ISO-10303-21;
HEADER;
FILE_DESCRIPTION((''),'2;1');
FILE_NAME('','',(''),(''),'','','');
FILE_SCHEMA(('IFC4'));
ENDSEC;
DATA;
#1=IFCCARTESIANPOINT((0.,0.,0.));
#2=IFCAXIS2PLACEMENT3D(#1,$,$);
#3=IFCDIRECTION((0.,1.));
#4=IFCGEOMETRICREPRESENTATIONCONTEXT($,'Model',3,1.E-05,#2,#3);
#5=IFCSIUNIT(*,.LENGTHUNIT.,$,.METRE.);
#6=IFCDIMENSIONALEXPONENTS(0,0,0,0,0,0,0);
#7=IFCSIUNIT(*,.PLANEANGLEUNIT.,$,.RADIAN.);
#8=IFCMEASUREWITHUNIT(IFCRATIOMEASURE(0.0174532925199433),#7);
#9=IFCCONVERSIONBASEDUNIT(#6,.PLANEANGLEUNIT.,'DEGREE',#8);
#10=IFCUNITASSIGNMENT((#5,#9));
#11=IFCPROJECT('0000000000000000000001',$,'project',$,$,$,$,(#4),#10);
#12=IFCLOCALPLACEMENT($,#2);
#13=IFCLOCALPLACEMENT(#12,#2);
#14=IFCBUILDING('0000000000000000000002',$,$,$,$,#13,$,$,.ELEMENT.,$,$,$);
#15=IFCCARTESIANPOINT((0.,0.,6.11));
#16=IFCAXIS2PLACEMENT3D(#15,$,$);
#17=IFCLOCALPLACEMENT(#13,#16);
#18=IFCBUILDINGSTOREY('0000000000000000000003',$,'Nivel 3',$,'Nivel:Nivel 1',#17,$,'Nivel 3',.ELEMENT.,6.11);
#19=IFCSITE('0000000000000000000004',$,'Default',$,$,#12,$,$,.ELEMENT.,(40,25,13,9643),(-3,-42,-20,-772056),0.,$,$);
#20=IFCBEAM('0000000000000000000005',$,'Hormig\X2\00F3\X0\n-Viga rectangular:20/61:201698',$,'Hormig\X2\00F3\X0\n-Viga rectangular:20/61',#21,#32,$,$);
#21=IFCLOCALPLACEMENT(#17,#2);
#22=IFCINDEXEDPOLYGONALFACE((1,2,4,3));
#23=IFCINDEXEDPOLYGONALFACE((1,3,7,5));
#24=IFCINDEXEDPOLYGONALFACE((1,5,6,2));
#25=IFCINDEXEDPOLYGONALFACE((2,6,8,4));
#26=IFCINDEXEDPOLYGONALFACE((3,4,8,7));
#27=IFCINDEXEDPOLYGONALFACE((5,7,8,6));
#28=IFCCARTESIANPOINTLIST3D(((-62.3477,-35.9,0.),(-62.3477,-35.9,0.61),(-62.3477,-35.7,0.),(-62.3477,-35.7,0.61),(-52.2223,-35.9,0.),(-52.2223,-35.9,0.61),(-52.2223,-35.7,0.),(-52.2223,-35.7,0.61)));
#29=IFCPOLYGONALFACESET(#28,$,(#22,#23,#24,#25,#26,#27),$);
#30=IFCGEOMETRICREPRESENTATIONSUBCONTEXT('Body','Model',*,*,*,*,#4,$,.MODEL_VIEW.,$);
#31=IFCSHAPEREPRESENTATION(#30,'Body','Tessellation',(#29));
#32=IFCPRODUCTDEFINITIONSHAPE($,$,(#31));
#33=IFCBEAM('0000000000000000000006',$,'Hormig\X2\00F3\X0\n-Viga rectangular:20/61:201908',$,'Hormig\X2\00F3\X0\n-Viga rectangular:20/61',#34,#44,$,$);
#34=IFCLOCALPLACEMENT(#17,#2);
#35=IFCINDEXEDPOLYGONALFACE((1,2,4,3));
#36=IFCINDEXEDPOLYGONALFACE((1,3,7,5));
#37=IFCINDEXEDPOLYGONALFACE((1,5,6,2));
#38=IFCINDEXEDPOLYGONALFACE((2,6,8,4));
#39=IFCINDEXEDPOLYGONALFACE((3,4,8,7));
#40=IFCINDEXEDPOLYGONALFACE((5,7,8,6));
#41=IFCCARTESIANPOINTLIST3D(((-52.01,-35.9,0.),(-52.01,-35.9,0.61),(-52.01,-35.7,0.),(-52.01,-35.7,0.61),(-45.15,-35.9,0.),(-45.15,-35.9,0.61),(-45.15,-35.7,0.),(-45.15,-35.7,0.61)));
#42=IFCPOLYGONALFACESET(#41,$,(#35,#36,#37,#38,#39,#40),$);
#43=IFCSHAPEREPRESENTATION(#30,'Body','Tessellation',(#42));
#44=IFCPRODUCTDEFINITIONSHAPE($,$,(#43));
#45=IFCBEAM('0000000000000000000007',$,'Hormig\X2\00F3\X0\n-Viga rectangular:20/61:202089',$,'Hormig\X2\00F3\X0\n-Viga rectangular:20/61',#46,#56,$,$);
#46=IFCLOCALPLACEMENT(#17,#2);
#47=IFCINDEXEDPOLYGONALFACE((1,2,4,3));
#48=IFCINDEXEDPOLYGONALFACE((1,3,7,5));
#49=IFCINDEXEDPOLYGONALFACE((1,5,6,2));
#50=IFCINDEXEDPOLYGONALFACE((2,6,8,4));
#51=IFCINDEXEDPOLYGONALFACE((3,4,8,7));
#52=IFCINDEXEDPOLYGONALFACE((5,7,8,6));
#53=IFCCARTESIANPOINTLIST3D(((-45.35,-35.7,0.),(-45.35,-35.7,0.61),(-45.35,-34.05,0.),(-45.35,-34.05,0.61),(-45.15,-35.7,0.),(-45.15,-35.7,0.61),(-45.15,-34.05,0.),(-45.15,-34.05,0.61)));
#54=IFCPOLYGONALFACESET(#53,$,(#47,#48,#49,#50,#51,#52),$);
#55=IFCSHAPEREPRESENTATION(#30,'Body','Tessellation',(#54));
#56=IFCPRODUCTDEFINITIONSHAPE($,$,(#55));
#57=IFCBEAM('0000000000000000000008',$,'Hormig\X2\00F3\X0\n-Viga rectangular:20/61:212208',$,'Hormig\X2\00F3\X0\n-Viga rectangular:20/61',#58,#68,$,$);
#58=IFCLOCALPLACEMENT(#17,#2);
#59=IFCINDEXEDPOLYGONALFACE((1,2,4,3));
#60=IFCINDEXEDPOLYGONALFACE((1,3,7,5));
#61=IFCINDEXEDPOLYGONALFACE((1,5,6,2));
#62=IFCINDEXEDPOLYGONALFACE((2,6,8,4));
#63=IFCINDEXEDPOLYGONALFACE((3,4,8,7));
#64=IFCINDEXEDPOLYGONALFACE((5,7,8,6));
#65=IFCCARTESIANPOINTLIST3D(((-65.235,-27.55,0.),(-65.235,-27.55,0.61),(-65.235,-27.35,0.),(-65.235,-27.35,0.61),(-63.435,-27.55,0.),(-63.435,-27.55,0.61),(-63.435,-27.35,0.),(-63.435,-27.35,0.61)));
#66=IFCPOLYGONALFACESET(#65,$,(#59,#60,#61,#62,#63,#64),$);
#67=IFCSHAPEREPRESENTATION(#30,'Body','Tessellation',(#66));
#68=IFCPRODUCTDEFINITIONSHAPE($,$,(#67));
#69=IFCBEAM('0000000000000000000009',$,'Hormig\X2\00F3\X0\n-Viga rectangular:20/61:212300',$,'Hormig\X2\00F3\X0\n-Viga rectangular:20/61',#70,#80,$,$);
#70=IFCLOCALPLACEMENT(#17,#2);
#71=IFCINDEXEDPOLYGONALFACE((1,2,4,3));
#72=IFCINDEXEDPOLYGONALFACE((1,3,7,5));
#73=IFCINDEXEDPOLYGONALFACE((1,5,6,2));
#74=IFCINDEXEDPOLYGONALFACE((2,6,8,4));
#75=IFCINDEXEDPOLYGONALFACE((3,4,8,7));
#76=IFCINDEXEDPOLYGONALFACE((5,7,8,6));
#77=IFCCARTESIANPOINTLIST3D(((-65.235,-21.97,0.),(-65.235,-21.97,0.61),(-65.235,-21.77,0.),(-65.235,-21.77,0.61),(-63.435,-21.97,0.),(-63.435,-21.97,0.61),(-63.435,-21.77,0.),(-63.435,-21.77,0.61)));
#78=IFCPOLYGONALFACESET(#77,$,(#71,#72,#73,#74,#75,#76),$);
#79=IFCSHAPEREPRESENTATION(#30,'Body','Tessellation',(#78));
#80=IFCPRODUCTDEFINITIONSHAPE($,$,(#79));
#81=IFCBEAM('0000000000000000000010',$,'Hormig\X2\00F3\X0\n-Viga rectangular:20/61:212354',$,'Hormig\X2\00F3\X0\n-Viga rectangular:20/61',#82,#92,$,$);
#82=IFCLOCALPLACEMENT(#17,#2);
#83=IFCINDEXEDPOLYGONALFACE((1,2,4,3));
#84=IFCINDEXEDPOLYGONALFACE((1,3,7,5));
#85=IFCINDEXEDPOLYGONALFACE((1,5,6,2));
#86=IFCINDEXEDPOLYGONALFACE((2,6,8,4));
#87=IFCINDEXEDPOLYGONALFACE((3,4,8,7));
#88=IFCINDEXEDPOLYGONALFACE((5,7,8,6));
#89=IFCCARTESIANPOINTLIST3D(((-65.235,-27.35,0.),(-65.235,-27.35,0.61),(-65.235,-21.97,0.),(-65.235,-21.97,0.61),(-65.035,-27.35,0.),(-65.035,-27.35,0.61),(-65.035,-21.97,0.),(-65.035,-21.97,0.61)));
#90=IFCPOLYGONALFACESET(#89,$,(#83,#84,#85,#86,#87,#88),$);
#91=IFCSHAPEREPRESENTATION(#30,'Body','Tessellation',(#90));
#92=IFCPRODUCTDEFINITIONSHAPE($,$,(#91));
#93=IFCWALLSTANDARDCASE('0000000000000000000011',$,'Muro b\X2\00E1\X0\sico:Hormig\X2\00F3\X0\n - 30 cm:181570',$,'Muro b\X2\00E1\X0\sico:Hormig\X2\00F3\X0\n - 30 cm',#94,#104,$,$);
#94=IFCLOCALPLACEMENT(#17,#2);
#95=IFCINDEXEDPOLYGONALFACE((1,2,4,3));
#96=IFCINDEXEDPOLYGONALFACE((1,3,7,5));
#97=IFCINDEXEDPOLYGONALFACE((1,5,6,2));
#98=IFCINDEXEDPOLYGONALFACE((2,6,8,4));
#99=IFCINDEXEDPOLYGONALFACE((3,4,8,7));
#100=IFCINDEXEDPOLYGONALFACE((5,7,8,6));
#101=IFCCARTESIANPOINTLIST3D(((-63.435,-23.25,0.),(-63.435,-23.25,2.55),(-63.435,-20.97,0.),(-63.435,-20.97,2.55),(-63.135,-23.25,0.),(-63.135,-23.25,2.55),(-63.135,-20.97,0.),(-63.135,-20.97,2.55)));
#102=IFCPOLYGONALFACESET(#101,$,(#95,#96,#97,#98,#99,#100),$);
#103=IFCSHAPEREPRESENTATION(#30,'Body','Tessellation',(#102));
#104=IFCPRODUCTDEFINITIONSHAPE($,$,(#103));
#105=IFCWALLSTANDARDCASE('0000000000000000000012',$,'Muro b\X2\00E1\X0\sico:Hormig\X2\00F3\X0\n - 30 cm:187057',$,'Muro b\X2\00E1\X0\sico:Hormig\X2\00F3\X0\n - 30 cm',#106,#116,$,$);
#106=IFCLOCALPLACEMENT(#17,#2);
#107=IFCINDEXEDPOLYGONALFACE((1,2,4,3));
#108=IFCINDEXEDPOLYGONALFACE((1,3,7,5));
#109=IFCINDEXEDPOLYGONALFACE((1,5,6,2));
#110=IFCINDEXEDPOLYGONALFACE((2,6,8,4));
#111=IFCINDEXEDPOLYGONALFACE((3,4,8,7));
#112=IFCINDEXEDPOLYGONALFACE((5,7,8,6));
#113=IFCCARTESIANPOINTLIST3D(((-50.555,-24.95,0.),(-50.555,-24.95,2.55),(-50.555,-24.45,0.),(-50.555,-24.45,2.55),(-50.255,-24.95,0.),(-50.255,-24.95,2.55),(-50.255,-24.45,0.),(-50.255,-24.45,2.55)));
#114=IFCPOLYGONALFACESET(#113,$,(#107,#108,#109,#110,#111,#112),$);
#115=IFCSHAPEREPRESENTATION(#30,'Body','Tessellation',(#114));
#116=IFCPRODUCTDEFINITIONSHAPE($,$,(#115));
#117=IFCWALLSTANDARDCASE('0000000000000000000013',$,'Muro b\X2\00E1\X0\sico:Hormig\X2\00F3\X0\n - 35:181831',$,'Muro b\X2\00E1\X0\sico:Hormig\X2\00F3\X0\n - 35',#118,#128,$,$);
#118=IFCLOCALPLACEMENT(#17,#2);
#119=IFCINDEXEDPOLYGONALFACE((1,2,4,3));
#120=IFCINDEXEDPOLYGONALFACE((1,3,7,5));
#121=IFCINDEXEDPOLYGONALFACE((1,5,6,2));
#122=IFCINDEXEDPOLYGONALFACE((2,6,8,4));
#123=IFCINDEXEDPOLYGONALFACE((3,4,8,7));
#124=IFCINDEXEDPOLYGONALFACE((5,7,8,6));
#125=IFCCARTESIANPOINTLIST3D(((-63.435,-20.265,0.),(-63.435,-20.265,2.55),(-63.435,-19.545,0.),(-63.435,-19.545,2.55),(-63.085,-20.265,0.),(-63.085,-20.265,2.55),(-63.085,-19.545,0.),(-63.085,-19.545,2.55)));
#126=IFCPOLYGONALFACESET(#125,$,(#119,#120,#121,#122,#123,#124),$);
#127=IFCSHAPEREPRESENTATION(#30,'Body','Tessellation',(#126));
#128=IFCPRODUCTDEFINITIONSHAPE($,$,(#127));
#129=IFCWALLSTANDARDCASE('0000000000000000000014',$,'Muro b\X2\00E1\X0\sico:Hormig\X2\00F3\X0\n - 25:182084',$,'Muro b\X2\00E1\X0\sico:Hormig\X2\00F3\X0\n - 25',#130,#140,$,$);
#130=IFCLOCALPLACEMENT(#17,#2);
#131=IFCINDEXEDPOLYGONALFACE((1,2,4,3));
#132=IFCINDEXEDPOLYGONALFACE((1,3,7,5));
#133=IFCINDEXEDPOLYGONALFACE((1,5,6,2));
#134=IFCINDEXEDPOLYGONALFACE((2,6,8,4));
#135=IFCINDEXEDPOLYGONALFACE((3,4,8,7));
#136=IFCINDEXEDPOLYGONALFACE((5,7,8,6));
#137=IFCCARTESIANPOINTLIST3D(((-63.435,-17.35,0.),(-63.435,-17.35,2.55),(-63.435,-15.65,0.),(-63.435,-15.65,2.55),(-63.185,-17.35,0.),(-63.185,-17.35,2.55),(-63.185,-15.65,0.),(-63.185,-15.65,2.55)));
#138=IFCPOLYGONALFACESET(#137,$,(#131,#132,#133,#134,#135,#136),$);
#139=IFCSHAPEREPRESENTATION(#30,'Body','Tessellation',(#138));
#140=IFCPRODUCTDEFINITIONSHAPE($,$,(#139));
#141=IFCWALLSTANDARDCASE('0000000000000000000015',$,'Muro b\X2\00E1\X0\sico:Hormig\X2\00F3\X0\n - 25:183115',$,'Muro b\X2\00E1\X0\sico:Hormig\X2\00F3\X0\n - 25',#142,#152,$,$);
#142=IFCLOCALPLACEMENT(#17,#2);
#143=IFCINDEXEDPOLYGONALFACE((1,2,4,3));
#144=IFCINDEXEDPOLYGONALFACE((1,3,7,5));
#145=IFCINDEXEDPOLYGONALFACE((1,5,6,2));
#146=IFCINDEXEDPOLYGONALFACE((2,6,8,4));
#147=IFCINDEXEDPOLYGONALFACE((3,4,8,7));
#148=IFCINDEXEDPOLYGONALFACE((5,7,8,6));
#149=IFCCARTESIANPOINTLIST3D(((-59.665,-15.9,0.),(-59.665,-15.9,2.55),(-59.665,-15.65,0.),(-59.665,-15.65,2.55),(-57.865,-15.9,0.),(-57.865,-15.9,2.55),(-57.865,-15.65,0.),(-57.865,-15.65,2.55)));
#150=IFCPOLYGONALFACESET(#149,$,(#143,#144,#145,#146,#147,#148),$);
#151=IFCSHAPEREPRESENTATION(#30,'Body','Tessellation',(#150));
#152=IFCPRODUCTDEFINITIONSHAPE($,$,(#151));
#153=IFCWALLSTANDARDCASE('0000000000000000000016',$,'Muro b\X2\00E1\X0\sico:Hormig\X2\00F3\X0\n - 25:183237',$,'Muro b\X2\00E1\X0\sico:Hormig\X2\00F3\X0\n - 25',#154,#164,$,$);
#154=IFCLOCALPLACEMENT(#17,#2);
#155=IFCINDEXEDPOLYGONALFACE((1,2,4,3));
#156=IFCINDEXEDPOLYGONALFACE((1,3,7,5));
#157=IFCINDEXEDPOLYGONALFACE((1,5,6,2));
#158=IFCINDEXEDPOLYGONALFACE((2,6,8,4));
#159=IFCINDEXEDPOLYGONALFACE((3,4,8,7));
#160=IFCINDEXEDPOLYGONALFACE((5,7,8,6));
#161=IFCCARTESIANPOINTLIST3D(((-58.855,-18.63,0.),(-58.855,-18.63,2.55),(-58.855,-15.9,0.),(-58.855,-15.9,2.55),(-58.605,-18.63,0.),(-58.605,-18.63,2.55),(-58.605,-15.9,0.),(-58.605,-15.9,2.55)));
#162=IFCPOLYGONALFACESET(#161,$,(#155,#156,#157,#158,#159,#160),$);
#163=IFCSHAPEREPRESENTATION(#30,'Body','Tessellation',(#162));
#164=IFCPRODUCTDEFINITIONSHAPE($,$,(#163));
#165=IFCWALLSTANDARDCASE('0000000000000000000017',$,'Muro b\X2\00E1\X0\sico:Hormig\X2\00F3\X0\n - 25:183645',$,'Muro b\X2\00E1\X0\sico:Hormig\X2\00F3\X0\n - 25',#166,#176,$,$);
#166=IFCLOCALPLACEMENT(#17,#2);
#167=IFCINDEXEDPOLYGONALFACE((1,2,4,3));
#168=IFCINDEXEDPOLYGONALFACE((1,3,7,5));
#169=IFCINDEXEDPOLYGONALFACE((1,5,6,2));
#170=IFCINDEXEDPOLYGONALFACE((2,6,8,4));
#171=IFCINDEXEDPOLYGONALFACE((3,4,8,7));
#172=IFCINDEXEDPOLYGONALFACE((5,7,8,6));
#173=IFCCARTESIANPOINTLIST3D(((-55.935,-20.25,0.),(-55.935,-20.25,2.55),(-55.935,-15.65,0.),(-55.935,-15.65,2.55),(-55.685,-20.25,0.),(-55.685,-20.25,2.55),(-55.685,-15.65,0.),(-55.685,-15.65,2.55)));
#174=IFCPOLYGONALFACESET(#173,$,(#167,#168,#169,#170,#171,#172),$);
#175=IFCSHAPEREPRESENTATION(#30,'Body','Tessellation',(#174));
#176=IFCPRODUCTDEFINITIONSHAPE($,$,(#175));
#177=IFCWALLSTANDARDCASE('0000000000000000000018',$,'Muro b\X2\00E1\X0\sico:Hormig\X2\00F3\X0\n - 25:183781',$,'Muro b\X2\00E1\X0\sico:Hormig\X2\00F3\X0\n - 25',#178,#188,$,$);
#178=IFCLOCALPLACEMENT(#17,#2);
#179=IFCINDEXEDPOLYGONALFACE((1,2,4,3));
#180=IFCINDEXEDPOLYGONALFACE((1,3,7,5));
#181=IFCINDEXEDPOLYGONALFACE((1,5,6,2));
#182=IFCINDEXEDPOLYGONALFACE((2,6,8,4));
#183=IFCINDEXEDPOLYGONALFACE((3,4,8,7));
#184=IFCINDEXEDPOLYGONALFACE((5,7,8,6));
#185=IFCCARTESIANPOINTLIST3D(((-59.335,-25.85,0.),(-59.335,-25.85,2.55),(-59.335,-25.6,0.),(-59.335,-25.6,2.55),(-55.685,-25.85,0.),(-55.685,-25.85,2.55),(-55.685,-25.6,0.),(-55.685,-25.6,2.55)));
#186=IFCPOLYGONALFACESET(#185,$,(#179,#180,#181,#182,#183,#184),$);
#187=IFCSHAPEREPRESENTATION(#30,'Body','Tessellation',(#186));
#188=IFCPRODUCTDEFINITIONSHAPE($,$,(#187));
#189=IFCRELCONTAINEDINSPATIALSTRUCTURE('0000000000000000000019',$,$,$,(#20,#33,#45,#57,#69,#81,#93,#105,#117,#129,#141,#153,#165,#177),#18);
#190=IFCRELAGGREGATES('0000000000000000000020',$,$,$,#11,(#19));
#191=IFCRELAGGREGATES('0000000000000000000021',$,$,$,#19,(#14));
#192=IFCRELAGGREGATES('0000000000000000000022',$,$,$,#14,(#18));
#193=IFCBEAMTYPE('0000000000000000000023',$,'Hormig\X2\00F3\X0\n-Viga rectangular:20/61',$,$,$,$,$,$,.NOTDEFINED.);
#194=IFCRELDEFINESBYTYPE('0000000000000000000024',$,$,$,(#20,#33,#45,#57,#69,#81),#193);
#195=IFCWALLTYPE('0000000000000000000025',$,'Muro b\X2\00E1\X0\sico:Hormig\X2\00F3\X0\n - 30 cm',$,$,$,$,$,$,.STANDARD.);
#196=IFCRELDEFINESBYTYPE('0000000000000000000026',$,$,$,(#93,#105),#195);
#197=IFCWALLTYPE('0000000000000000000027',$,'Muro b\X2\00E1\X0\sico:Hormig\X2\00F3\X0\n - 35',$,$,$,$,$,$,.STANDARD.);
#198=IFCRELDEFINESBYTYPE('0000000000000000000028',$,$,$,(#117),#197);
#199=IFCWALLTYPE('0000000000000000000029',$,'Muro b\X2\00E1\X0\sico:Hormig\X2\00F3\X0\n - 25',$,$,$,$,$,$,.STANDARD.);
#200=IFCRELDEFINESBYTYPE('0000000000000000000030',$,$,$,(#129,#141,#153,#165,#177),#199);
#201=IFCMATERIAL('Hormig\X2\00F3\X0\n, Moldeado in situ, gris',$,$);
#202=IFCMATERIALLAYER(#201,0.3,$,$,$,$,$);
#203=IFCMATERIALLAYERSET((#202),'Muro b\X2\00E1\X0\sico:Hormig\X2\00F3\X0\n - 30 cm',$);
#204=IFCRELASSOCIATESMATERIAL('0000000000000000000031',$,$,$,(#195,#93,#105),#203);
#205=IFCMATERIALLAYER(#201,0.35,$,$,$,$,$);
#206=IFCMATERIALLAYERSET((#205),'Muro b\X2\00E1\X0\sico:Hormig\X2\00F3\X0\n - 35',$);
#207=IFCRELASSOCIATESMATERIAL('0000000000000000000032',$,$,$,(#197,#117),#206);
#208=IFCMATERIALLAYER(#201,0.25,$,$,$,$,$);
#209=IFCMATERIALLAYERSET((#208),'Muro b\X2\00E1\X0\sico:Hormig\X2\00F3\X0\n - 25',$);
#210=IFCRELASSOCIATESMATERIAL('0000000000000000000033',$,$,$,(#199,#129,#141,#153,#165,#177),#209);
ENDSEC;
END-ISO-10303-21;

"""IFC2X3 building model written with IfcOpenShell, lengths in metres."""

from ifc_helpers import new_model, entity, si_unit, converted_unit, direction, frame, frame_2d, origin, origin_2d_with_axis, place, context, subcontext, project, spatial, rectangle, extrude, material, layer, layer_set, layer_usage, type_object, element, save


model = new_model("IFC2X3")

# Units and contexts
model_context = context("Model", 3, precision=1e-05, world=origin(), true_north=direction((0.0, 1.0)))
body_context = subcontext(model_context, "Body", "Model", "MODEL_VIEW")
ifc_project = project(units=[si_unit("LENGTHUNIT", "METRE"), converted_unit("PLANEANGLEUNIT", "DEGREE", entity("IfcRatioMeasure", 0.0174532925199433), si_unit("PLANEANGLEUNIT", "RADIAN"), dimensions=[0, 0, 0, 0, 0, 0, 0])], contexts=[model_context])

# Site, building, storey
site_placement = place(None, origin())
site = spatial("IfcSite", under=ifc_project, at=site_placement, Name="Default", CompositionType="ELEMENT", RefLatitude=(40, 25, 13, 9643), RefLongitude=(-3, -42, -20, -772056), RefElevation=0.0)
building_placement = place(site_placement, origin())
building = spatial("IfcBuilding", under=site, at=building_placement, CompositionType="ELEMENT")
storey_placement = place(building_placement, frame((0.0, 0.0, 6.11)))
storey = spatial("IfcBuildingStorey", under=building, at=storey_placement, Name="Nivel 3", ObjectType="Nivel:Nivel 1", LongName="Nivel 3", CompositionType="ELEMENT", Elevation=6.11)

# Beams
beam_type = type_object("IfcBeamType", Name="Hormigón-Viga rectangular:20/61", PredefinedType="NOTDEFINED")
beam_1_placement = place(storey_placement, frame((-62.335, -35.8, 0.61)))
element("IfcBeam", 1, at=beam_1_placement, inside=storey, type_object=beam_type, Name="Hormigón-Viga rectangular:20/61:201698", ObjectType="Hormigón-Viga rectangular:20/61", context=body_context, shape_type="SweptSolid", body=[
    extrude(rectangle(XDim=0.61, YDim=0.2, at=frame_2d((0.0, 0.0), x_axis=(1.0, 0.0))), frame((-0.0127, 0.0, -0.305), z_axis=(1.0, 0.0, 0.0), x_axis=(0.0, 0.0, -1.0)), (0.0, 0.0, 1.0), 10.1254),
])
beam_2_placement = place(storey_placement, frame((-51.9973, -35.8, 0.61)))
element("IfcBeam", 2, at=beam_2_placement, inside=storey, type_object=beam_type, Name="Hormigón-Viga rectangular:20/61:201908", ObjectType="Hormigón-Viga rectangular:20/61", context=body_context, shape_type="SweptSolid", body=[
    extrude(rectangle(XDim=0.61, YDim=0.2, at=frame_2d((0.0, 0.0), x_axis=(1.0, 0.0))), frame((-0.0127, 0.0, -0.305), z_axis=(1.0, 0.0, 0.0), x_axis=(0.0, 0.0, -1.0)), (0.0, 0.0, 1.0), 6.86),
])
beam_3_placement = place(storey_placement, frame((-45.25, -35.8, 0.61), z_axis=(0.0, 0.0, 1.0), x_axis=(0.0, 1.0, 0.0)))
element("IfcBeam", 3, at=beam_3_placement, inside=storey, type_object=beam_type, Name="Hormigón-Viga rectangular:20/61:202089", ObjectType="Hormigón-Viga rectangular:20/61", context=body_context, shape_type="SweptSolid", body=[
    extrude(rectangle(XDim=0.61, YDim=0.2, at=origin_2d_with_axis()), frame((0.1, 0.0, -0.305), z_axis=(1.0, 0.0, 0.0), x_axis=(0.0, 0.0, -1.0)), (0.0, 0.0, 1.0), 1.65),
])
beam_4_placement = place(storey_placement, frame((-65.135, -27.45, 0.61)))
element("IfcBeam", 4, at=beam_4_placement, inside=storey, type_object=beam_type, Name="Hormigón-Viga rectangular:20/61:212208", ObjectType="Hormigón-Viga rectangular:20/61", context=body_context, shape_type="SweptSolid", body=[
    extrude(rectangle(XDim=0.61, YDim=0.2, at=frame_2d((0.0, 0.0), x_axis=(1.0, 0.0))), frame((-0.1, 0.0, -0.305), z_axis=(1.0, 0.0, 0.0), x_axis=(0.0, 0.0, -1.0)), (0.0, 0.0, 1.0), 1.8),
])
beam_5_placement = place(storey_placement, frame((-65.135, -21.87, 0.61)))
element("IfcBeam", 5, at=beam_5_placement, inside=storey, type_object=beam_type, Name="Hormigón-Viga rectangular:20/61:212300", ObjectType="Hormigón-Viga rectangular:20/61", context=body_context, shape_type="SweptSolid", body=[
    extrude(rectangle(XDim=0.61, YDim=0.2, at=frame_2d((0.0, 0.0), x_axis=(1.0, 0.0))), frame((-0.1, 0.0, -0.305), z_axis=(1.0, 0.0, 0.0), x_axis=(0.0, 0.0, -1.0)), (0.0, 0.0, 1.0), 1.8),
])
beam_6_placement = place(storey_placement, frame((-65.135, -21.87, 0.61), z_axis=(0.0, 0.0, 1.0), x_axis=(0.0, -1.0, 0.0)))
element("IfcBeam", 6, at=beam_6_placement, inside=storey, type_object=beam_type, Name="Hormigón-Viga rectangular:20/61:212354", ObjectType="Hormigón-Viga rectangular:20/61", context=body_context, shape_type="SweptSolid", body=[
    extrude(rectangle(XDim=0.61, YDim=0.2, at=origin_2d_with_axis()), frame((0.1, 0.0, -0.305), z_axis=(1.0, 0.0, 0.0), x_axis=(0.0, 0.0, -1.0)), (0.0, 0.0, 1.0), 5.38),
])

# Walls
ifc_material = material(Name="Hormigón, Moldeado in situ, gris")
ifc_layer_1 = layer(ifc_material, 0.3)
ifc_layer_set_1 = layer_set([ifc_layer_1], Name="Muro básico:Hormigón - 30 cm")
ifc_layer_usage_1 = layer_usage(ifc_layer_set_1, "AXIS2", "NEGATIVE", 0.15)
wall_type_1 = type_object("IfcWallType", Name="Muro básico:Hormigón - 30 cm", PredefinedType="STANDARD", material=ifc_layer_set_1)
wall_1_placement = place(storey_placement, frame((-63.285, -23.25, 0.0), z_axis=(0.0, 0.0, 1.0), x_axis=(0.0, 1.0, 0.0)))
element("IfcWallStandardCase", 7, at=wall_1_placement, inside=storey, type_object=wall_type_1, material=ifc_layer_usage_1, Name="Muro básico:Hormigón - 30 cm:181570", ObjectType="Muro básico:Hormigón - 30 cm", context=body_context, shape_type="SweptSolid", body=[
    extrude(rectangle(XDim=2.28, YDim=0.3, at=frame_2d((1.14, 0.0), x_axis=(-1.0, 0.0))), origin(), (0.0, 0.0, 1.0), 2.55),
])
ifc_layer_usage_2 = layer_usage(ifc_layer_set_1, "AXIS2", "NEGATIVE", 0.15)
wall_2_placement = place(storey_placement, frame((-50.405, -24.95, 0.0), z_axis=(0.0, 0.0, 1.0), x_axis=(0.0, 1.0, 0.0)))
element("IfcWallStandardCase", 8, at=wall_2_placement, inside=storey, type_object=wall_type_1, material=ifc_layer_usage_2, Name="Muro básico:Hormigón - 30 cm:187057", ObjectType="Muro básico:Hormigón - 30 cm", context=body_context, shape_type="SweptSolid", body=[
    extrude(rectangle(XDim=0.5, YDim=0.3, at=frame_2d((0.25, 0.0), x_axis=(-1.0, 0.0))), origin(), (0.0, 0.0, 1.0), 2.55),
])
ifc_layer_2 = layer(ifc_material, 0.35)
ifc_layer_set_2 = layer_set([ifc_layer_2], Name="Muro básico:Hormigón - 35")
ifc_layer_usage_3 = layer_usage(ifc_layer_set_2, "AXIS2", "NEGATIVE", 0.175)
wall_type_2 = type_object("IfcWallType", Name="Muro básico:Hormigón - 35", PredefinedType="STANDARD", material=ifc_layer_set_2)
wall_3_placement = place(storey_placement, frame((-63.26, -20.265, 0.0), z_axis=(0.0, 0.0, 1.0), x_axis=(0.0, 1.0, 0.0)))
element("IfcWallStandardCase", 9, at=wall_3_placement, inside=storey, type_object=wall_type_2, material=ifc_layer_usage_3, Name="Muro básico:Hormigón - 35:181831", ObjectType="Muro básico:Hormigón - 35", context=body_context, shape_type="SweptSolid", body=[
    extrude(rectangle(XDim=0.72, YDim=0.35, at=frame_2d((0.36, 0.0), x_axis=(-1.0, 0.0))), origin(), (0.0, 0.0, 1.0), 2.55),
])
ifc_layer_3 = layer(ifc_material, 0.25)
ifc_layer_set_3 = layer_set([ifc_layer_3], Name="Muro básico:Hormigón - 25")
ifc_layer_usage_4 = layer_usage(ifc_layer_set_3, "AXIS2", "NEGATIVE", 0.125)
wall_type_3 = type_object("IfcWallType", Name="Muro básico:Hormigón - 25", PredefinedType="STANDARD", material=ifc_layer_set_3)
wall_4_placement = place(storey_placement, frame((-63.31, -17.35, 0.0), z_axis=(0.0, 0.0, 1.0), x_axis=(0.0, 1.0, 0.0)))
element("IfcWallStandardCase", 10, at=wall_4_placement, inside=storey, type_object=wall_type_3, material=ifc_layer_usage_4, Name="Muro básico:Hormigón - 25:182084", ObjectType="Muro básico:Hormigón - 25", context=body_context, shape_type="SweptSolid", body=[
    extrude(rectangle(XDim=1.7, YDim=0.25, at=frame_2d((0.85, 0.0), x_axis=(-1.0, 0.0))), origin(), (0.0, 0.0, 1.0), 2.55),
])
ifc_layer_usage_5 = layer_usage(ifc_layer_set_3, "AXIS2", "NEGATIVE", 0.125)
wall_5_placement = place(storey_placement, frame((-59.665, -15.775, 0.0)))
element("IfcWallStandardCase", 11, at=wall_5_placement, inside=storey, type_object=wall_type_3, material=ifc_layer_usage_5, Name="Muro básico:Hormigón - 25:183115", ObjectType="Muro básico:Hormigón - 25", context=body_context, shape_type="SweptSolid", body=[
    extrude(rectangle(XDim=1.8, YDim=0.25, at=frame_2d((0.9, 0.0), x_axis=(-1.0, 0.0))), origin(), (0.0, 0.0, 1.0), 2.55),
])
ifc_layer_usage_6 = layer_usage(ifc_layer_set_3, "AXIS2", "NEGATIVE", 0.125)
wall_6_placement = place(storey_placement, frame((-58.73, -18.63, 0.0), z_axis=(0.0, 0.0, 1.0), x_axis=(0.0, 1.0, 0.0)))
element("IfcWallStandardCase", 12, at=wall_6_placement, inside=storey, type_object=wall_type_3, material=ifc_layer_usage_6, Name="Muro básico:Hormigón - 25:183237", ObjectType="Muro básico:Hormigón - 25", context=body_context, shape_type="SweptSolid", body=[
    extrude(rectangle(XDim=2.73, YDim=0.25, at=frame_2d((1.365, 0.0), x_axis=(-1.0, 0.0))), origin(), (0.0, 0.0, 1.0), 2.55),
])
ifc_layer_usage_7 = layer_usage(ifc_layer_set_3, "AXIS2", "NEGATIVE", 0.125)
wall_7_placement = place(storey_placement, frame((-55.81, -20.25, 0.0), z_axis=(0.0, 0.0, 1.0), x_axis=(0.0, 1.0, 0.0)))
element("IfcWallStandardCase", 13, at=wall_7_placement, inside=storey, type_object=wall_type_3, material=ifc_layer_usage_7, Name="Muro básico:Hormigón - 25:183645", ObjectType="Muro básico:Hormigón - 25", context=body_context, shape_type="SweptSolid", body=[
    extrude(rectangle(XDim=4.6, YDim=0.25, at=frame_2d((2.3, 0.0), x_axis=(-1.0, 0.0))), origin(), (0.0, 0.0, 1.0), 2.55),
])
ifc_layer_usage_8 = layer_usage(ifc_layer_set_3, "AXIS2", "NEGATIVE", 0.125)
wall_8_placement = place(storey_placement, frame((-59.335, -25.725, 0.0)))
element("IfcWallStandardCase", 14, at=wall_8_placement, inside=storey, type_object=wall_type_3, material=ifc_layer_usage_8, Name="Muro básico:Hormigón - 25:183781", ObjectType="Muro básico:Hormigón - 25", context=body_context, shape_type="SweptSolid", body=[
    extrude(rectangle(XDim=3.65, YDim=0.25, at=frame_2d((1.825, 0.0), x_axis=(-1.0, 0.0))), origin(), (0.0, 0.0, 1.0), 2.55),
])

save(model, "model.ifc")
